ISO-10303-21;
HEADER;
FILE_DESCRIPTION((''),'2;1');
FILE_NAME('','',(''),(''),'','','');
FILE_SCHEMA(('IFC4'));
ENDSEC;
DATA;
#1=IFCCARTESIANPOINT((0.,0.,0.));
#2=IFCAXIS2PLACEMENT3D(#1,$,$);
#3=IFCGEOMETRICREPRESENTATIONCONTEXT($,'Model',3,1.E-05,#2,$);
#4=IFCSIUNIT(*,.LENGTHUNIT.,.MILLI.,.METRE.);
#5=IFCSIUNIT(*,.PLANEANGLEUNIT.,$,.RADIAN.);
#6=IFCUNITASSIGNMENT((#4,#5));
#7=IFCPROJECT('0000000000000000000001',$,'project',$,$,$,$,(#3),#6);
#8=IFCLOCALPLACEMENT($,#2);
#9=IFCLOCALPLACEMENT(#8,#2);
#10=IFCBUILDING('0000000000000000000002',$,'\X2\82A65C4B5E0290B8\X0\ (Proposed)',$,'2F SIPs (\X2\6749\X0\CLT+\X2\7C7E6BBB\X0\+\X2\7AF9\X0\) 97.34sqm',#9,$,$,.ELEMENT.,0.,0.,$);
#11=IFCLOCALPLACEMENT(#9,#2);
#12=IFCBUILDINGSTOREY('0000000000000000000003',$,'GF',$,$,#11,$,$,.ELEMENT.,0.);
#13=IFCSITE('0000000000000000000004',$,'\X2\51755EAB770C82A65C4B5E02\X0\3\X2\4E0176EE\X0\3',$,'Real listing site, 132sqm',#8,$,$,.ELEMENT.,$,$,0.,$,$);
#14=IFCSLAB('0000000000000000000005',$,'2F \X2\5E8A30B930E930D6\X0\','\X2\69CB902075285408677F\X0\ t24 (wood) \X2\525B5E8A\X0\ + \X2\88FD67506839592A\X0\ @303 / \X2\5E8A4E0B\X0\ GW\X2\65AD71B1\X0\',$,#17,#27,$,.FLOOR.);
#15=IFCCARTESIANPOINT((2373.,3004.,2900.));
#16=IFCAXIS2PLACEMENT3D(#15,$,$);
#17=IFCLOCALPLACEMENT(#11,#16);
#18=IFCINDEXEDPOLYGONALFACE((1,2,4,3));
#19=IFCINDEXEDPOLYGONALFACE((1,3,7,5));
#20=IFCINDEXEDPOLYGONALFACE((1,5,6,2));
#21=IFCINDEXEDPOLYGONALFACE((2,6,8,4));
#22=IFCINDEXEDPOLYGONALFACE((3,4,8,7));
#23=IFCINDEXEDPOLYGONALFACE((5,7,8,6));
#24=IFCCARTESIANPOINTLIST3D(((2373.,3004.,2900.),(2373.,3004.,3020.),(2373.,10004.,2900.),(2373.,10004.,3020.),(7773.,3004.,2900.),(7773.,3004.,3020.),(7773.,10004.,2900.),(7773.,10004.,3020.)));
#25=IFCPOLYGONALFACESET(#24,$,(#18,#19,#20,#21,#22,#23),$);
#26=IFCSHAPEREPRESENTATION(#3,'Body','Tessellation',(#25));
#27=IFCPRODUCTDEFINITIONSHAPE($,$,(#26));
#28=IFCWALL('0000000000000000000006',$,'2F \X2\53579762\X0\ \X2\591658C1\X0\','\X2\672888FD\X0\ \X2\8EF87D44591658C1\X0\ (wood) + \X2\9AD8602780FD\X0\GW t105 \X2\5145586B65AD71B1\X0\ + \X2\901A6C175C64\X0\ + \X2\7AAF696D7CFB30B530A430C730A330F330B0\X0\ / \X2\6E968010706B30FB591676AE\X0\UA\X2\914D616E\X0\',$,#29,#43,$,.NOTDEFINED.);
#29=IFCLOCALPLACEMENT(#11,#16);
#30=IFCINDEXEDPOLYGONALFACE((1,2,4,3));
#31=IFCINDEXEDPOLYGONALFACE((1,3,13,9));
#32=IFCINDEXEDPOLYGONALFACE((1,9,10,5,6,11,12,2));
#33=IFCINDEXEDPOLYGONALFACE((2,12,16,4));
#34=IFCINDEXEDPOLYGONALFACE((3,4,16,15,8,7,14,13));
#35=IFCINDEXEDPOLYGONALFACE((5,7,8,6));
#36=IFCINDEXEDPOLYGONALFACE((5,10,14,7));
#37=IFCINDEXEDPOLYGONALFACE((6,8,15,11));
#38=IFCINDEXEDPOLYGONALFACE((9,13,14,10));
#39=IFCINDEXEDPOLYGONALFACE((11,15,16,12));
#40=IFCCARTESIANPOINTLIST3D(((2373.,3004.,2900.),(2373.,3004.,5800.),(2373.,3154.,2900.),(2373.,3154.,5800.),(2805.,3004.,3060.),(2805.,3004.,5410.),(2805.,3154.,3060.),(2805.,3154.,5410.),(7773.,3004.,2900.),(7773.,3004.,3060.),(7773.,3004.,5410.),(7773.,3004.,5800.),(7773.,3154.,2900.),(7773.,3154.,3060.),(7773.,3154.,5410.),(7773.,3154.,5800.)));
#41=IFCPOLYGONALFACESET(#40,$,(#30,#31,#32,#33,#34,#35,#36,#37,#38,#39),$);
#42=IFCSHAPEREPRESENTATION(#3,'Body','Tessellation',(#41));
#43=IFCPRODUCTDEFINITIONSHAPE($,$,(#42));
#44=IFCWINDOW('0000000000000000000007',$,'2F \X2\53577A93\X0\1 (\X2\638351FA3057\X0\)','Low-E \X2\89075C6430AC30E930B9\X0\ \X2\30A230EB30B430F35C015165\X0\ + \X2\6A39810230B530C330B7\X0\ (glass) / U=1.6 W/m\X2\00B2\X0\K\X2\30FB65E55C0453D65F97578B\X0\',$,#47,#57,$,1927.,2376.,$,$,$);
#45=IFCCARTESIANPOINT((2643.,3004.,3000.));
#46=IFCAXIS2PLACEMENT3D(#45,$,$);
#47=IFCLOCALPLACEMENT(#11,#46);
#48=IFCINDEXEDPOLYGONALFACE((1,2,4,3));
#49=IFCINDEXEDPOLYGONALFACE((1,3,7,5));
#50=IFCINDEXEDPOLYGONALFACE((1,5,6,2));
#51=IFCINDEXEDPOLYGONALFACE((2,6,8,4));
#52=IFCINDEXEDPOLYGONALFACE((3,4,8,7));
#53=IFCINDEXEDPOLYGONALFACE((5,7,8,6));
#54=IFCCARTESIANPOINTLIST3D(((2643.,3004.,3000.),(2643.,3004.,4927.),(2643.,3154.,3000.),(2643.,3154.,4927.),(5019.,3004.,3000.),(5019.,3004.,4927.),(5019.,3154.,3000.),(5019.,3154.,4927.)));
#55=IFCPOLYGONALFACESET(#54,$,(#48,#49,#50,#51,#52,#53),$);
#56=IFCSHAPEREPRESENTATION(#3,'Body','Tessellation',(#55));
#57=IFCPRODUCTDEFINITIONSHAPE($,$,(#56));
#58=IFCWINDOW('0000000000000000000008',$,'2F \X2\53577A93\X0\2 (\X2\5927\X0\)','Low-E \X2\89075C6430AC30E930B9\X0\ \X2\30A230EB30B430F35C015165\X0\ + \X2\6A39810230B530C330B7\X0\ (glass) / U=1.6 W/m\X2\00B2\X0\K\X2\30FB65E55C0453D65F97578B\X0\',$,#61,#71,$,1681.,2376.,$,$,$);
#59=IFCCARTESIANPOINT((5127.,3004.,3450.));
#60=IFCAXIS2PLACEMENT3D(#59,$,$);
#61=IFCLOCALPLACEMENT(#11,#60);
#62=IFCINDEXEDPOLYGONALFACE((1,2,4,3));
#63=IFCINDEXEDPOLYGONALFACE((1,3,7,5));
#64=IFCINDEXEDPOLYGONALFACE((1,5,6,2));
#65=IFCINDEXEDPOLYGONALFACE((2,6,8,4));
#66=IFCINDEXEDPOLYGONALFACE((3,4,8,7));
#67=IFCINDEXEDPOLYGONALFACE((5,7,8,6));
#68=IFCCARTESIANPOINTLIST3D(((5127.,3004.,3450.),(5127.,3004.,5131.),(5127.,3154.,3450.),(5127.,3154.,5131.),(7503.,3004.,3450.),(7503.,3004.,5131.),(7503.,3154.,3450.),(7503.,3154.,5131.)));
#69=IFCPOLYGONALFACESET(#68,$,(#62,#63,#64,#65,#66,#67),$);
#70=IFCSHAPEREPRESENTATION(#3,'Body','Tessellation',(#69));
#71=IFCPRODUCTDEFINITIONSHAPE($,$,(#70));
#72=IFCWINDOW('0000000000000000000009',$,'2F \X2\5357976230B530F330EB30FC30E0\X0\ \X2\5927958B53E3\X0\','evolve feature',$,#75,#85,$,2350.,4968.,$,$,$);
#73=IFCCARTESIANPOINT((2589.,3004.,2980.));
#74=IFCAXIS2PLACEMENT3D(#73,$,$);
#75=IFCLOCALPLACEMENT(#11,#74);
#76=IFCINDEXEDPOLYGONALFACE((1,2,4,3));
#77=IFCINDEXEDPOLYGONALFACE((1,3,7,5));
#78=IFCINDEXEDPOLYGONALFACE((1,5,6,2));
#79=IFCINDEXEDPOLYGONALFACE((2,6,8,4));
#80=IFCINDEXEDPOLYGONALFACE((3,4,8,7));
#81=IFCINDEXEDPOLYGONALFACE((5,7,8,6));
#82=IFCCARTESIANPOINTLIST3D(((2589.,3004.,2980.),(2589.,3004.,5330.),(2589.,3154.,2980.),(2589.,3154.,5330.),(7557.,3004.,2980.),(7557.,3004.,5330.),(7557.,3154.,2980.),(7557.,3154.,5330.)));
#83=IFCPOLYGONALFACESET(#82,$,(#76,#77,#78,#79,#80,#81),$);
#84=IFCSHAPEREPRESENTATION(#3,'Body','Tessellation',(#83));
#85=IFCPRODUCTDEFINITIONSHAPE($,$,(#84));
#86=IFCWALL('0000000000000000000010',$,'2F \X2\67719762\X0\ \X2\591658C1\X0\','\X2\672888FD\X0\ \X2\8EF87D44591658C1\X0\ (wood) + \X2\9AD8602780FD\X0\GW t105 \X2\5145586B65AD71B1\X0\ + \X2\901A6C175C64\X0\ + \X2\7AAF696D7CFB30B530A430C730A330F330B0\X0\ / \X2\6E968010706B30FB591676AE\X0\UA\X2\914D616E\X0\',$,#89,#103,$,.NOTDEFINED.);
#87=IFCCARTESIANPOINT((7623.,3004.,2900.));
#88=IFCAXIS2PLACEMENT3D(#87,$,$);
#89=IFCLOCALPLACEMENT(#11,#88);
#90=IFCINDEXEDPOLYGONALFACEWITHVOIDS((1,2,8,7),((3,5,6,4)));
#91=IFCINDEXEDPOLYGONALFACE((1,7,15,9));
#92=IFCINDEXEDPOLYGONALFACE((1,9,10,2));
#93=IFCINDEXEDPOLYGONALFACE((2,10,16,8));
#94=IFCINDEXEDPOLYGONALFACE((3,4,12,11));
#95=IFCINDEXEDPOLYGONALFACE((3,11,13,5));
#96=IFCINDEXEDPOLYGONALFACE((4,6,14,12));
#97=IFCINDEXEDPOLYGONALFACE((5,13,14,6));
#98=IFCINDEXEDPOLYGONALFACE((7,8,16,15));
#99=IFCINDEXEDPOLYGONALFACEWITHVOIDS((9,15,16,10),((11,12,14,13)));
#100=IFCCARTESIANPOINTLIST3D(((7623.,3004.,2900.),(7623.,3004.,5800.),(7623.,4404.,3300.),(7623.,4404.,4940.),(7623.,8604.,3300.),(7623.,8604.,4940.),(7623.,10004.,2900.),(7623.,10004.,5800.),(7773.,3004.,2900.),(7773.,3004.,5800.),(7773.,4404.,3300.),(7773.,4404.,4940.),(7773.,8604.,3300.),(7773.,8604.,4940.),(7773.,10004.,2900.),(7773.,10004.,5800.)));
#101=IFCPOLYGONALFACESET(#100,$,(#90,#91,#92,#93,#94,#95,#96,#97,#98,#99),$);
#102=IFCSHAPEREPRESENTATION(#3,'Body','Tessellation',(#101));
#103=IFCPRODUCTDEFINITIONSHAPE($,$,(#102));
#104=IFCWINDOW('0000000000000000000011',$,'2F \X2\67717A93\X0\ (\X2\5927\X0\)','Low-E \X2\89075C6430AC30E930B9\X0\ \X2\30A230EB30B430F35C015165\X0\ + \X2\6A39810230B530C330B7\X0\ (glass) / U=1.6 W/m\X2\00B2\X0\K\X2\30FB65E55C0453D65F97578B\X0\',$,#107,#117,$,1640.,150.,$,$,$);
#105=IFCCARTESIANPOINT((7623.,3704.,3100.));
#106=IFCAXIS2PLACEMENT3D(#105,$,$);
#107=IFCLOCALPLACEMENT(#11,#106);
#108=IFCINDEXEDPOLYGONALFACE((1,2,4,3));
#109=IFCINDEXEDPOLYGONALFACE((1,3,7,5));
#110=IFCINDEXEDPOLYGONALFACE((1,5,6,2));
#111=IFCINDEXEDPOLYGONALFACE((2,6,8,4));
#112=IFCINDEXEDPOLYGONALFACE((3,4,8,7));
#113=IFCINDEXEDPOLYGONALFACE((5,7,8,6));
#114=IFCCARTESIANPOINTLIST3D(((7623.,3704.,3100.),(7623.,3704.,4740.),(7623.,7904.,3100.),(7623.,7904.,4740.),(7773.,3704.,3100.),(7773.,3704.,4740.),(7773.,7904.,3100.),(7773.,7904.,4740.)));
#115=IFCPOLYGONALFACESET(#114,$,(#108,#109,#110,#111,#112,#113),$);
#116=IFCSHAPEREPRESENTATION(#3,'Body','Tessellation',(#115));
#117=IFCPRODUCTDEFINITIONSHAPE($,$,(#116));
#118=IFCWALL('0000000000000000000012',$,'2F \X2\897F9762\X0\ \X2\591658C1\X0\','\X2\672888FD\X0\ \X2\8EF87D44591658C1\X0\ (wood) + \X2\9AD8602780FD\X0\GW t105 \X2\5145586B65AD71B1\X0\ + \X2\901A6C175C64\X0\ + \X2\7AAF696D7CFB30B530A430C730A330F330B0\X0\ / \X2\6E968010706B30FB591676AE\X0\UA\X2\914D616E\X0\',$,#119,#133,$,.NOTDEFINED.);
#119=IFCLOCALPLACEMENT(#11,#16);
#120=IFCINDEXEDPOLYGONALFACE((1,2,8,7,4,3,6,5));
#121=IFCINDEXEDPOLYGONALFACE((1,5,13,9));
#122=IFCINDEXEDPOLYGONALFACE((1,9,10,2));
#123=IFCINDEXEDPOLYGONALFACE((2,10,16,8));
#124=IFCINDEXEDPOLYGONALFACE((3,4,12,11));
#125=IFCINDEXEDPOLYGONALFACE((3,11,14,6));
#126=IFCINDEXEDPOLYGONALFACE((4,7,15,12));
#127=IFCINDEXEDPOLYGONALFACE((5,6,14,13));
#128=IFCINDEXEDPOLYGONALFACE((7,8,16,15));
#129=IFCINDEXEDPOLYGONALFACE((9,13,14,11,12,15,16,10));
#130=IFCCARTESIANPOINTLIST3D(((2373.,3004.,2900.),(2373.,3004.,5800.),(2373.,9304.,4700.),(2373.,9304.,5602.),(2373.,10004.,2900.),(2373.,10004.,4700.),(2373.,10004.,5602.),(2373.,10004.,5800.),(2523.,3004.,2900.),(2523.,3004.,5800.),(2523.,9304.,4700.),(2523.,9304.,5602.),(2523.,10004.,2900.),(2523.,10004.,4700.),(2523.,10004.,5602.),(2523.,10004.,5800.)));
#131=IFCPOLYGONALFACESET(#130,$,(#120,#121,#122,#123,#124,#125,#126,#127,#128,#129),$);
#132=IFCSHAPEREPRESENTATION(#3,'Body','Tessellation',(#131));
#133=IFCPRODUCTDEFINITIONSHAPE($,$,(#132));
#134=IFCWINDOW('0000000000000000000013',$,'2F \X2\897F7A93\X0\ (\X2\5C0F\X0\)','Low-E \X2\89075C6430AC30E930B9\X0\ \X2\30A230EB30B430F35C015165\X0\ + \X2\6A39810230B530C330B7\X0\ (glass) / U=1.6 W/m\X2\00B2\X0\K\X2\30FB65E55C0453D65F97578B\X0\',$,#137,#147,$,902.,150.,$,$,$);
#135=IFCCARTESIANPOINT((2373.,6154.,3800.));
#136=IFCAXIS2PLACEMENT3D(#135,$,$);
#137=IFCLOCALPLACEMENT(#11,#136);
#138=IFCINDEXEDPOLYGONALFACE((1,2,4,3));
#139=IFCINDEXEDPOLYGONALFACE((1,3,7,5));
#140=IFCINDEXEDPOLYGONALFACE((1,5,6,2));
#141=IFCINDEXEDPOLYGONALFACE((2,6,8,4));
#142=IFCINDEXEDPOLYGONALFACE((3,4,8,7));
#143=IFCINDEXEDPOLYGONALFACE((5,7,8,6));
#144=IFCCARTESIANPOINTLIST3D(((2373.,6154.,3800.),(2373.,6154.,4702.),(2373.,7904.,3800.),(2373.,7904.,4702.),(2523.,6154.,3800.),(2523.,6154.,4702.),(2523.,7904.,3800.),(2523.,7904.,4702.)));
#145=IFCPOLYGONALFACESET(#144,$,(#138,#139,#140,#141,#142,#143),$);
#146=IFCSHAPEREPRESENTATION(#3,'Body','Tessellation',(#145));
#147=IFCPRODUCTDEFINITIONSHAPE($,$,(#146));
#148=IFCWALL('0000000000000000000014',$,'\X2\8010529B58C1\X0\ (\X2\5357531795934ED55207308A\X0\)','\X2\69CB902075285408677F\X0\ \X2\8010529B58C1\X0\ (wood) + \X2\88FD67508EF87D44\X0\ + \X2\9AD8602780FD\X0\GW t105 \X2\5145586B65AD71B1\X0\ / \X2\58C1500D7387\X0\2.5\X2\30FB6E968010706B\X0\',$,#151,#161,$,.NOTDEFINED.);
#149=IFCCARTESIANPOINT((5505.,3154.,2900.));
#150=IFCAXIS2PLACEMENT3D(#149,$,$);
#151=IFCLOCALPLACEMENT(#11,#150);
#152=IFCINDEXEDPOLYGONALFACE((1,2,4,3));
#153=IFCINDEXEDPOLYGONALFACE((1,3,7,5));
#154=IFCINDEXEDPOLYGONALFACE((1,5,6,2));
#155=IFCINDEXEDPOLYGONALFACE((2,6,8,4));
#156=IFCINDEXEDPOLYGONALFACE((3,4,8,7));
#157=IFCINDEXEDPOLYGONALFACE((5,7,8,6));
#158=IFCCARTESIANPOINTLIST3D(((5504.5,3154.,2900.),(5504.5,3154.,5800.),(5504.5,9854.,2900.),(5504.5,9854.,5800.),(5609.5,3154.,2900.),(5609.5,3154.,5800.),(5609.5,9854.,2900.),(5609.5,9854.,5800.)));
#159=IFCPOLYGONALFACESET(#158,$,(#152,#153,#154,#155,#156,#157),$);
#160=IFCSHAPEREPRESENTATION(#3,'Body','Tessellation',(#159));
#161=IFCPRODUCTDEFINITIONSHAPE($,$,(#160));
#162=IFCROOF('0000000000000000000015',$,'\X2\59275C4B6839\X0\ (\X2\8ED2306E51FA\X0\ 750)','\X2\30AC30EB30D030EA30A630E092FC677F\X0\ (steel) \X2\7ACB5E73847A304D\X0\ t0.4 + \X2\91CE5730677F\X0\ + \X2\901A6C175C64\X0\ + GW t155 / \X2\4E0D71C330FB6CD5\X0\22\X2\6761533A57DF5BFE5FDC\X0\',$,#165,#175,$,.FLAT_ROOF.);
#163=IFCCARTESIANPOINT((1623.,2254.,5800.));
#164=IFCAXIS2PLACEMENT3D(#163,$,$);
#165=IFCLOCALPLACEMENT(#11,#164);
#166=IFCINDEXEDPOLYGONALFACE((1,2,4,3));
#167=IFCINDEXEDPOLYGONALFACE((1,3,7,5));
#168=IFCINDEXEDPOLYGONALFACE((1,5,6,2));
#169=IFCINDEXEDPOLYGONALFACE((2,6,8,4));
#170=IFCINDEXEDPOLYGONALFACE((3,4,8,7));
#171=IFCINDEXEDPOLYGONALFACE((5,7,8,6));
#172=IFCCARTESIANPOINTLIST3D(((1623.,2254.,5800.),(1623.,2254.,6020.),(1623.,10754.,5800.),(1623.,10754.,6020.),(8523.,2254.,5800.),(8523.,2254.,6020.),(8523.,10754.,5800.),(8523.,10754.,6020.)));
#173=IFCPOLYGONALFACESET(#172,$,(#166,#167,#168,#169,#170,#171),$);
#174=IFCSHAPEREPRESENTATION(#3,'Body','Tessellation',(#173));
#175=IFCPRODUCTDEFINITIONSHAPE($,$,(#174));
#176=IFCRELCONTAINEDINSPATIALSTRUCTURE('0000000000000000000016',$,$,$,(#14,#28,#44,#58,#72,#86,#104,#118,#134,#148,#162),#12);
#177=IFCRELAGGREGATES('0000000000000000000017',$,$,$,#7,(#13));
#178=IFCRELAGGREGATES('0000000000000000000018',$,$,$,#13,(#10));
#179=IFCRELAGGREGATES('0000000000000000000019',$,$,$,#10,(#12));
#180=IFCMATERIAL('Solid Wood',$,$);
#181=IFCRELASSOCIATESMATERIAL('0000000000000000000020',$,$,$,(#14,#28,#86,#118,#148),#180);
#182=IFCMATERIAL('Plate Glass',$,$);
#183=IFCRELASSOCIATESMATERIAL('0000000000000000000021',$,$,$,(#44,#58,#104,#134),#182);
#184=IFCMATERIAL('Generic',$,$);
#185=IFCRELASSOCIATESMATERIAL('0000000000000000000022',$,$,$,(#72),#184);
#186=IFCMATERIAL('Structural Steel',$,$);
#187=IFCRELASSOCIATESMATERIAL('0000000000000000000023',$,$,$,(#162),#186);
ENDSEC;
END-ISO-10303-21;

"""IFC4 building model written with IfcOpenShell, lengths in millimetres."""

from ifc_helpers import new_model, si_unit, frame, frame_2d, origin, place, context, project, spatial, rectangle, extrude, material, element, fill, save


model = new_model("IFC4")

# Units and contexts
model_context = context("Model", 3, precision=1e-05, world=origin())
ifc_project = project(units=[si_unit("LENGTHUNIT", "METRE", prefix="MILLI"), si_unit("PLANEANGLEUNIT", "RADIAN")], contexts=[model_context])

# Site, building, storey
site_placement = place(None, origin())
site = spatial("IfcSite", under=ifc_project, at=site_placement, Name="兵庫県芦屋市3丁目3", ObjectType="Real listing site, 132sqm", CompositionType="ELEMENT", RefElevation=0.0)
building_placement = place(site_placement, origin())
building = spatial("IfcBuilding", under=site, at=building_placement, Name="芦屋市邸 (Proposed)", ObjectType="2F SIPs (杉CLT+籾殻+竹) 97.34sqm", CompositionType="ELEMENT", ElevationOfRefHeight=0.0, ElevationOfTerrain=0.0)
storey_placement = place(building_placement, origin())
storey = spatial("IfcBuildingStorey", under=building, at=storey_placement, Name="GF", CompositionType="ELEMENT", Elevation=0.0)

# Slab
ifc_material_1 = material(Name="Solid Wood")
slab_placement = place(storey_placement, frame((2373.0, 3004.0, 2900.0)))
element("IfcSlab", 1, at=slab_placement, inside=storey, material=ifc_material_1, Name="2F 床スラブ", Description="構造用合板 t24 (wood) 剛床 + 製材根太 @303 / 床下 GW断熱", PredefinedType="FLOOR", context=model_context, shape_type="SweptSolid", body=[
    extrude(rectangle(XDim=5400.0, YDim=7000.0, at=frame_2d((2700.0, 3500.0))), frame((2373.0, 3004.0, 2900.0)), (0.0, 0.0, 1.0), 120.0),
])

# Wall, openings, windows
wall_1_placement = place(storey_placement, frame((2373.0, 3004.0, 2900.0)))
wall_1 = element("IfcWall", 2, at=wall_1_placement, inside=storey, material=ifc_material_1, Name="2F 南面 外壁", Description="木製 軸組外壁 (wood) + 高性能GW t105 充填断熱 + 通気層 + 窯業系サイディング / 準耐火・外皮UA配慮", PredefinedType="NOTDEFINED", context=model_context, shape_type="SweptSolid", body=[
    extrude(rectangle(XDim=5400.0, YDim=150.0, at=frame_2d((2700.0, 75.0))), frame((2373.0, 3004.0, 2900.0)), (0.0, 0.0, 1.0), 2900.0),
])
opening_1_placement = place(storey_placement, frame((2643.0, 3004.0, 3000.0)))
opening_1 = element("IfcOpeningElement", 3, at=opening_1_placement, cuts=wall_1, PredefinedType="NOTDEFINED", context=model_context, shape_type="SweptSolid", body=[
    extrude(rectangle(XDim=2376.0, YDim=150.0, at=frame_2d((1188.0, 75.0))), frame((2643.0, 3004.0, 3000.0)), (0.0, 0.0, 1.0), 1927.0),
])
opening_2_placement = place(storey_placement, frame((5127.0, 3004.0, 3450.0)))
opening_2 = element("IfcOpeningElement", 4, at=opening_2_placement, cuts=wall_1, PredefinedType="NOTDEFINED", context=model_context, shape_type="SweptSolid", body=[
    extrude(rectangle(XDim=2376.0, YDim=150.0, at=frame_2d((1188.0, 75.0))), frame((5127.0, 3004.0, 3450.0)), (0.0, 0.0, 1.0), 1681.0),
])
opening_3_placement = place(storey_placement, frame((2589.0, 3004.0, 2980.0)))
opening_3 = element("IfcOpeningElement", 5, at=opening_3_placement, cuts=wall_1, PredefinedType="NOTDEFINED", context=model_context, shape_type="SweptSolid", body=[
    extrude(rectangle(XDim=4968.0, YDim=150.0, at=frame_2d((2484.0, 75.0))), frame((2589.0, 3004.0, 2980.0)), (0.0, 0.0, 1.0), 2350.0),
])
ifc_material_2 = material(Name="Plate Glass")
window_1_placement = place(storey_placement, frame((2643.0, 3004.0, 3000.0)))
window_1 = element("IfcWindow", 6, at=window_1_placement, inside=storey, material=ifc_material_2, Name="2F 南窓1 (掃出し)", Description="Low-E 複層ガラス アルゴン封入 + 樹脂サッシ (glass) / U=1.6 W/m²K・日射取得型", OverallHeight=1927.0, OverallWidth=2376.0, context=model_context, shape_type="SweptSolid", body=[
    extrude(rectangle(XDim=2376.0, YDim=150.0, at=frame_2d((1188.0, 75.0))), frame((2643.0, 3004.0, 3000.0)), (0.0, 0.0, 1.0), 1927.0),
])
fill(opening_1, window_1)
window_2_placement = place(storey_placement, frame((5127.0, 3004.0, 3450.0)))
window_2 = element("IfcWindow", 7, at=window_2_placement, inside=storey, material=ifc_material_2, Name="2F 南窓2 (大)", Description="Low-E 複層ガラス アルゴン封入 + 樹脂サッシ (glass) / U=1.6 W/m²K・日射取得型", OverallHeight=1681.0, OverallWidth=2376.0, context=model_context, shape_type="SweptSolid", body=[
    extrude(rectangle(XDim=2376.0, YDim=150.0, at=frame_2d((1188.0, 75.0))), frame((5127.0, 3004.0, 3450.0)), (0.0, 0.0, 1.0), 1681.0),
])
fill(opening_2, window_2)
ifc_material_3 = material(Name="Generic")
window_3_placement = place(storey_placement, frame((2589.0, 3004.0, 2980.0)))
window_3 = element("IfcWindow", 8, at=window_3_placement, inside=storey, material=ifc_material_3, Name="2F 南面サンルーム 大開口", Description="evolve feature", OverallHeight=2350.0, OverallWidth=4968.0, context=model_context, shape_type="SweptSolid", body=[
    extrude(rectangle(XDim=4968.0, YDim=150.0, at=frame_2d((2484.0, 75.0))), frame((2589.0, 3004.0, 2980.0)), (0.0, 0.0, 1.0), 2350.0),
])
fill(opening_3, window_3)

# Walls, openings, windows
wall_2_placement = place(storey_placement, frame((7623.0, 3004.0, 2900.0)))
wall_2 = element("IfcWall", 9, at=wall_2_placement, inside=storey, material=ifc_material_1, Name="2F 東面 外壁", Description="木製 軸組外壁 (wood) + 高性能GW t105 充填断熱 + 通気層 + 窯業系サイディング / 準耐火・外皮UA配慮", PredefinedType="NOTDEFINED", context=model_context, shape_type="SweptSolid", body=[
    extrude(rectangle(XDim=150.0, YDim=7000.0, at=frame_2d((75.0, 3500.0))), frame((7623.0, 3004.0, 2900.0)), (0.0, 0.0, 1.0), 2900.0),
])
opening_4_placement = place(storey_placement, frame((7623.0, 3704.0, 3100.0)))
opening_4 = element("IfcOpeningElement", 10, at=opening_4_placement, cuts=wall_2, PredefinedType="NOTDEFINED", context=model_context, shape_type="SweptSolid", body=[
    extrude(rectangle(XDim=150.0, YDim=4200.0, at=frame_2d((75.0, 2100.0))), frame((7623.0, 3704.0, 3100.0)), (0.0, 0.0, 1.0), 1640.0),
])
window_4_placement = place(storey_placement, frame((7623.0, 3704.0, 3100.0)))
window_4 = element("IfcWindow", 11, at=window_4_placement, inside=storey, material=ifc_material_2, Name="2F 東窓 (大)", Description="Low-E 複層ガラス アルゴン封入 + 樹脂サッシ (glass) / U=1.6 W/m²K・日射取得型", OverallHeight=1640.0, OverallWidth=150.0, context=model_context, shape_type="SweptSolid", body=[
    extrude(rectangle(XDim=150.0, YDim=4200.0, at=frame_2d((75.0, 2100.0))), frame((7623.0, 3704.0, 3100.0)), (0.0, 0.0, 1.0), 1640.0),
])
fill(opening_4, window_4)
wall_3_placement = place(storey_placement, frame((2373.0, 3004.0, 2900.0)))
wall_3 = element("IfcWall", 12, at=wall_3_placement, inside=storey, material=ifc_material_1, Name="2F 西面 外壁", Description="木製 軸組外壁 (wood) + 高性能GW t105 充填断熱 + 通気層 + 窯業系サイディング / 準耐火・外皮UA配慮", PredefinedType="NOTDEFINED", context=model_context, shape_type="SweptSolid", body=[
    extrude(rectangle(XDim=150.0, YDim=7000.0, at=frame_2d((75.0, 3500.0))), frame((2373.0, 3004.0, 2900.0)), (0.0, 0.0, 1.0), 2900.0),
])
opening_5_placement = place(storey_placement, frame((2373.0, 6154.0, 3800.0)))
opening_5 = element("IfcOpeningElement", 13, at=opening_5_placement, cuts=wall_3, PredefinedType="NOTDEFINED", context=model_context, shape_type="SweptSolid", body=[
    extrude(rectangle(XDim=150.0, YDim=1750.0, at=frame_2d((75.0, 875.0))), frame((2373.0, 6154.0, 3800.0)), (0.0, 0.0, 1.0), 902.0),
])
window_5_placement = place(storey_placement, frame((2373.0, 6154.0, 3800.0)))
window_5 = element("IfcWindow", 14, at=window_5_placement, inside=storey, material=ifc_material_2, Name="2F 西窓 (小)", Description="Low-E 複層ガラス アルゴン封入 + 樹脂サッシ (glass) / U=1.6 W/m²K・日射取得型", OverallHeight=902.0, OverallWidth=150.0, context=model_context, shape_type="SweptSolid", body=[
    extrude(rectangle(XDim=150.0, YDim=1750.0, at=frame_2d((75.0, 875.0))), frame((2373.0, 6154.0, 3800.0)), (0.0, 0.0, 1.0), 902.0),
])
fill(opening_5, window_5)

# Wall
wall_4_placement = place(storey_placement, frame((5505.0, 3154.0, 2900.0)))
element("IfcWall", 15, at=wall_4_placement, inside=storey, material=ifc_material_1, Name="耐力壁 (南北間仕切り)", Description="構造用合板 耐力壁 (wood) + 製材軸組 + 高性能GW t105 充填断熱 / 壁倍率2.5・準耐火", PredefinedType="NOTDEFINED", context=model_context, shape_type="SweptSolid", body=[
    extrude(rectangle(XDim=105.0, YDim=6700.0, at=frame_2d((52.0, 3350.0))), frame((5505.0, 3154.0, 2900.0)), (0.0, 0.0, 1.0), 2900.0),
])

# Roof
ifc_material_4 = material(Name="Structural Steel")
roof_1_placement = place(storey_placement, frame((1623.0, 2254.0, 5800.0)))
element("IfcRoof", 16, at=roof_1_placement, inside=storey, material=ifc_material_4, Name="大屋根 (軒の出 750)", Description="ガルバリウム鋼板 (steel) 立平葺き t0.4 + 野地板 + 通気層 + GW t155 / 不燃・法22条区域対応", PredefinedType="FLAT_ROOF", context=model_context, shape_type="SweptSolid", body=[
    extrude(rectangle(XDim=6900.0, YDim=8500.0, at=frame_2d((3450.0, 4250.0))), frame((1623.0, 2254.0, 5800.0)), (0.0, 0.0, 1.0), 220.0),
])

save(model, "model.ifc")
